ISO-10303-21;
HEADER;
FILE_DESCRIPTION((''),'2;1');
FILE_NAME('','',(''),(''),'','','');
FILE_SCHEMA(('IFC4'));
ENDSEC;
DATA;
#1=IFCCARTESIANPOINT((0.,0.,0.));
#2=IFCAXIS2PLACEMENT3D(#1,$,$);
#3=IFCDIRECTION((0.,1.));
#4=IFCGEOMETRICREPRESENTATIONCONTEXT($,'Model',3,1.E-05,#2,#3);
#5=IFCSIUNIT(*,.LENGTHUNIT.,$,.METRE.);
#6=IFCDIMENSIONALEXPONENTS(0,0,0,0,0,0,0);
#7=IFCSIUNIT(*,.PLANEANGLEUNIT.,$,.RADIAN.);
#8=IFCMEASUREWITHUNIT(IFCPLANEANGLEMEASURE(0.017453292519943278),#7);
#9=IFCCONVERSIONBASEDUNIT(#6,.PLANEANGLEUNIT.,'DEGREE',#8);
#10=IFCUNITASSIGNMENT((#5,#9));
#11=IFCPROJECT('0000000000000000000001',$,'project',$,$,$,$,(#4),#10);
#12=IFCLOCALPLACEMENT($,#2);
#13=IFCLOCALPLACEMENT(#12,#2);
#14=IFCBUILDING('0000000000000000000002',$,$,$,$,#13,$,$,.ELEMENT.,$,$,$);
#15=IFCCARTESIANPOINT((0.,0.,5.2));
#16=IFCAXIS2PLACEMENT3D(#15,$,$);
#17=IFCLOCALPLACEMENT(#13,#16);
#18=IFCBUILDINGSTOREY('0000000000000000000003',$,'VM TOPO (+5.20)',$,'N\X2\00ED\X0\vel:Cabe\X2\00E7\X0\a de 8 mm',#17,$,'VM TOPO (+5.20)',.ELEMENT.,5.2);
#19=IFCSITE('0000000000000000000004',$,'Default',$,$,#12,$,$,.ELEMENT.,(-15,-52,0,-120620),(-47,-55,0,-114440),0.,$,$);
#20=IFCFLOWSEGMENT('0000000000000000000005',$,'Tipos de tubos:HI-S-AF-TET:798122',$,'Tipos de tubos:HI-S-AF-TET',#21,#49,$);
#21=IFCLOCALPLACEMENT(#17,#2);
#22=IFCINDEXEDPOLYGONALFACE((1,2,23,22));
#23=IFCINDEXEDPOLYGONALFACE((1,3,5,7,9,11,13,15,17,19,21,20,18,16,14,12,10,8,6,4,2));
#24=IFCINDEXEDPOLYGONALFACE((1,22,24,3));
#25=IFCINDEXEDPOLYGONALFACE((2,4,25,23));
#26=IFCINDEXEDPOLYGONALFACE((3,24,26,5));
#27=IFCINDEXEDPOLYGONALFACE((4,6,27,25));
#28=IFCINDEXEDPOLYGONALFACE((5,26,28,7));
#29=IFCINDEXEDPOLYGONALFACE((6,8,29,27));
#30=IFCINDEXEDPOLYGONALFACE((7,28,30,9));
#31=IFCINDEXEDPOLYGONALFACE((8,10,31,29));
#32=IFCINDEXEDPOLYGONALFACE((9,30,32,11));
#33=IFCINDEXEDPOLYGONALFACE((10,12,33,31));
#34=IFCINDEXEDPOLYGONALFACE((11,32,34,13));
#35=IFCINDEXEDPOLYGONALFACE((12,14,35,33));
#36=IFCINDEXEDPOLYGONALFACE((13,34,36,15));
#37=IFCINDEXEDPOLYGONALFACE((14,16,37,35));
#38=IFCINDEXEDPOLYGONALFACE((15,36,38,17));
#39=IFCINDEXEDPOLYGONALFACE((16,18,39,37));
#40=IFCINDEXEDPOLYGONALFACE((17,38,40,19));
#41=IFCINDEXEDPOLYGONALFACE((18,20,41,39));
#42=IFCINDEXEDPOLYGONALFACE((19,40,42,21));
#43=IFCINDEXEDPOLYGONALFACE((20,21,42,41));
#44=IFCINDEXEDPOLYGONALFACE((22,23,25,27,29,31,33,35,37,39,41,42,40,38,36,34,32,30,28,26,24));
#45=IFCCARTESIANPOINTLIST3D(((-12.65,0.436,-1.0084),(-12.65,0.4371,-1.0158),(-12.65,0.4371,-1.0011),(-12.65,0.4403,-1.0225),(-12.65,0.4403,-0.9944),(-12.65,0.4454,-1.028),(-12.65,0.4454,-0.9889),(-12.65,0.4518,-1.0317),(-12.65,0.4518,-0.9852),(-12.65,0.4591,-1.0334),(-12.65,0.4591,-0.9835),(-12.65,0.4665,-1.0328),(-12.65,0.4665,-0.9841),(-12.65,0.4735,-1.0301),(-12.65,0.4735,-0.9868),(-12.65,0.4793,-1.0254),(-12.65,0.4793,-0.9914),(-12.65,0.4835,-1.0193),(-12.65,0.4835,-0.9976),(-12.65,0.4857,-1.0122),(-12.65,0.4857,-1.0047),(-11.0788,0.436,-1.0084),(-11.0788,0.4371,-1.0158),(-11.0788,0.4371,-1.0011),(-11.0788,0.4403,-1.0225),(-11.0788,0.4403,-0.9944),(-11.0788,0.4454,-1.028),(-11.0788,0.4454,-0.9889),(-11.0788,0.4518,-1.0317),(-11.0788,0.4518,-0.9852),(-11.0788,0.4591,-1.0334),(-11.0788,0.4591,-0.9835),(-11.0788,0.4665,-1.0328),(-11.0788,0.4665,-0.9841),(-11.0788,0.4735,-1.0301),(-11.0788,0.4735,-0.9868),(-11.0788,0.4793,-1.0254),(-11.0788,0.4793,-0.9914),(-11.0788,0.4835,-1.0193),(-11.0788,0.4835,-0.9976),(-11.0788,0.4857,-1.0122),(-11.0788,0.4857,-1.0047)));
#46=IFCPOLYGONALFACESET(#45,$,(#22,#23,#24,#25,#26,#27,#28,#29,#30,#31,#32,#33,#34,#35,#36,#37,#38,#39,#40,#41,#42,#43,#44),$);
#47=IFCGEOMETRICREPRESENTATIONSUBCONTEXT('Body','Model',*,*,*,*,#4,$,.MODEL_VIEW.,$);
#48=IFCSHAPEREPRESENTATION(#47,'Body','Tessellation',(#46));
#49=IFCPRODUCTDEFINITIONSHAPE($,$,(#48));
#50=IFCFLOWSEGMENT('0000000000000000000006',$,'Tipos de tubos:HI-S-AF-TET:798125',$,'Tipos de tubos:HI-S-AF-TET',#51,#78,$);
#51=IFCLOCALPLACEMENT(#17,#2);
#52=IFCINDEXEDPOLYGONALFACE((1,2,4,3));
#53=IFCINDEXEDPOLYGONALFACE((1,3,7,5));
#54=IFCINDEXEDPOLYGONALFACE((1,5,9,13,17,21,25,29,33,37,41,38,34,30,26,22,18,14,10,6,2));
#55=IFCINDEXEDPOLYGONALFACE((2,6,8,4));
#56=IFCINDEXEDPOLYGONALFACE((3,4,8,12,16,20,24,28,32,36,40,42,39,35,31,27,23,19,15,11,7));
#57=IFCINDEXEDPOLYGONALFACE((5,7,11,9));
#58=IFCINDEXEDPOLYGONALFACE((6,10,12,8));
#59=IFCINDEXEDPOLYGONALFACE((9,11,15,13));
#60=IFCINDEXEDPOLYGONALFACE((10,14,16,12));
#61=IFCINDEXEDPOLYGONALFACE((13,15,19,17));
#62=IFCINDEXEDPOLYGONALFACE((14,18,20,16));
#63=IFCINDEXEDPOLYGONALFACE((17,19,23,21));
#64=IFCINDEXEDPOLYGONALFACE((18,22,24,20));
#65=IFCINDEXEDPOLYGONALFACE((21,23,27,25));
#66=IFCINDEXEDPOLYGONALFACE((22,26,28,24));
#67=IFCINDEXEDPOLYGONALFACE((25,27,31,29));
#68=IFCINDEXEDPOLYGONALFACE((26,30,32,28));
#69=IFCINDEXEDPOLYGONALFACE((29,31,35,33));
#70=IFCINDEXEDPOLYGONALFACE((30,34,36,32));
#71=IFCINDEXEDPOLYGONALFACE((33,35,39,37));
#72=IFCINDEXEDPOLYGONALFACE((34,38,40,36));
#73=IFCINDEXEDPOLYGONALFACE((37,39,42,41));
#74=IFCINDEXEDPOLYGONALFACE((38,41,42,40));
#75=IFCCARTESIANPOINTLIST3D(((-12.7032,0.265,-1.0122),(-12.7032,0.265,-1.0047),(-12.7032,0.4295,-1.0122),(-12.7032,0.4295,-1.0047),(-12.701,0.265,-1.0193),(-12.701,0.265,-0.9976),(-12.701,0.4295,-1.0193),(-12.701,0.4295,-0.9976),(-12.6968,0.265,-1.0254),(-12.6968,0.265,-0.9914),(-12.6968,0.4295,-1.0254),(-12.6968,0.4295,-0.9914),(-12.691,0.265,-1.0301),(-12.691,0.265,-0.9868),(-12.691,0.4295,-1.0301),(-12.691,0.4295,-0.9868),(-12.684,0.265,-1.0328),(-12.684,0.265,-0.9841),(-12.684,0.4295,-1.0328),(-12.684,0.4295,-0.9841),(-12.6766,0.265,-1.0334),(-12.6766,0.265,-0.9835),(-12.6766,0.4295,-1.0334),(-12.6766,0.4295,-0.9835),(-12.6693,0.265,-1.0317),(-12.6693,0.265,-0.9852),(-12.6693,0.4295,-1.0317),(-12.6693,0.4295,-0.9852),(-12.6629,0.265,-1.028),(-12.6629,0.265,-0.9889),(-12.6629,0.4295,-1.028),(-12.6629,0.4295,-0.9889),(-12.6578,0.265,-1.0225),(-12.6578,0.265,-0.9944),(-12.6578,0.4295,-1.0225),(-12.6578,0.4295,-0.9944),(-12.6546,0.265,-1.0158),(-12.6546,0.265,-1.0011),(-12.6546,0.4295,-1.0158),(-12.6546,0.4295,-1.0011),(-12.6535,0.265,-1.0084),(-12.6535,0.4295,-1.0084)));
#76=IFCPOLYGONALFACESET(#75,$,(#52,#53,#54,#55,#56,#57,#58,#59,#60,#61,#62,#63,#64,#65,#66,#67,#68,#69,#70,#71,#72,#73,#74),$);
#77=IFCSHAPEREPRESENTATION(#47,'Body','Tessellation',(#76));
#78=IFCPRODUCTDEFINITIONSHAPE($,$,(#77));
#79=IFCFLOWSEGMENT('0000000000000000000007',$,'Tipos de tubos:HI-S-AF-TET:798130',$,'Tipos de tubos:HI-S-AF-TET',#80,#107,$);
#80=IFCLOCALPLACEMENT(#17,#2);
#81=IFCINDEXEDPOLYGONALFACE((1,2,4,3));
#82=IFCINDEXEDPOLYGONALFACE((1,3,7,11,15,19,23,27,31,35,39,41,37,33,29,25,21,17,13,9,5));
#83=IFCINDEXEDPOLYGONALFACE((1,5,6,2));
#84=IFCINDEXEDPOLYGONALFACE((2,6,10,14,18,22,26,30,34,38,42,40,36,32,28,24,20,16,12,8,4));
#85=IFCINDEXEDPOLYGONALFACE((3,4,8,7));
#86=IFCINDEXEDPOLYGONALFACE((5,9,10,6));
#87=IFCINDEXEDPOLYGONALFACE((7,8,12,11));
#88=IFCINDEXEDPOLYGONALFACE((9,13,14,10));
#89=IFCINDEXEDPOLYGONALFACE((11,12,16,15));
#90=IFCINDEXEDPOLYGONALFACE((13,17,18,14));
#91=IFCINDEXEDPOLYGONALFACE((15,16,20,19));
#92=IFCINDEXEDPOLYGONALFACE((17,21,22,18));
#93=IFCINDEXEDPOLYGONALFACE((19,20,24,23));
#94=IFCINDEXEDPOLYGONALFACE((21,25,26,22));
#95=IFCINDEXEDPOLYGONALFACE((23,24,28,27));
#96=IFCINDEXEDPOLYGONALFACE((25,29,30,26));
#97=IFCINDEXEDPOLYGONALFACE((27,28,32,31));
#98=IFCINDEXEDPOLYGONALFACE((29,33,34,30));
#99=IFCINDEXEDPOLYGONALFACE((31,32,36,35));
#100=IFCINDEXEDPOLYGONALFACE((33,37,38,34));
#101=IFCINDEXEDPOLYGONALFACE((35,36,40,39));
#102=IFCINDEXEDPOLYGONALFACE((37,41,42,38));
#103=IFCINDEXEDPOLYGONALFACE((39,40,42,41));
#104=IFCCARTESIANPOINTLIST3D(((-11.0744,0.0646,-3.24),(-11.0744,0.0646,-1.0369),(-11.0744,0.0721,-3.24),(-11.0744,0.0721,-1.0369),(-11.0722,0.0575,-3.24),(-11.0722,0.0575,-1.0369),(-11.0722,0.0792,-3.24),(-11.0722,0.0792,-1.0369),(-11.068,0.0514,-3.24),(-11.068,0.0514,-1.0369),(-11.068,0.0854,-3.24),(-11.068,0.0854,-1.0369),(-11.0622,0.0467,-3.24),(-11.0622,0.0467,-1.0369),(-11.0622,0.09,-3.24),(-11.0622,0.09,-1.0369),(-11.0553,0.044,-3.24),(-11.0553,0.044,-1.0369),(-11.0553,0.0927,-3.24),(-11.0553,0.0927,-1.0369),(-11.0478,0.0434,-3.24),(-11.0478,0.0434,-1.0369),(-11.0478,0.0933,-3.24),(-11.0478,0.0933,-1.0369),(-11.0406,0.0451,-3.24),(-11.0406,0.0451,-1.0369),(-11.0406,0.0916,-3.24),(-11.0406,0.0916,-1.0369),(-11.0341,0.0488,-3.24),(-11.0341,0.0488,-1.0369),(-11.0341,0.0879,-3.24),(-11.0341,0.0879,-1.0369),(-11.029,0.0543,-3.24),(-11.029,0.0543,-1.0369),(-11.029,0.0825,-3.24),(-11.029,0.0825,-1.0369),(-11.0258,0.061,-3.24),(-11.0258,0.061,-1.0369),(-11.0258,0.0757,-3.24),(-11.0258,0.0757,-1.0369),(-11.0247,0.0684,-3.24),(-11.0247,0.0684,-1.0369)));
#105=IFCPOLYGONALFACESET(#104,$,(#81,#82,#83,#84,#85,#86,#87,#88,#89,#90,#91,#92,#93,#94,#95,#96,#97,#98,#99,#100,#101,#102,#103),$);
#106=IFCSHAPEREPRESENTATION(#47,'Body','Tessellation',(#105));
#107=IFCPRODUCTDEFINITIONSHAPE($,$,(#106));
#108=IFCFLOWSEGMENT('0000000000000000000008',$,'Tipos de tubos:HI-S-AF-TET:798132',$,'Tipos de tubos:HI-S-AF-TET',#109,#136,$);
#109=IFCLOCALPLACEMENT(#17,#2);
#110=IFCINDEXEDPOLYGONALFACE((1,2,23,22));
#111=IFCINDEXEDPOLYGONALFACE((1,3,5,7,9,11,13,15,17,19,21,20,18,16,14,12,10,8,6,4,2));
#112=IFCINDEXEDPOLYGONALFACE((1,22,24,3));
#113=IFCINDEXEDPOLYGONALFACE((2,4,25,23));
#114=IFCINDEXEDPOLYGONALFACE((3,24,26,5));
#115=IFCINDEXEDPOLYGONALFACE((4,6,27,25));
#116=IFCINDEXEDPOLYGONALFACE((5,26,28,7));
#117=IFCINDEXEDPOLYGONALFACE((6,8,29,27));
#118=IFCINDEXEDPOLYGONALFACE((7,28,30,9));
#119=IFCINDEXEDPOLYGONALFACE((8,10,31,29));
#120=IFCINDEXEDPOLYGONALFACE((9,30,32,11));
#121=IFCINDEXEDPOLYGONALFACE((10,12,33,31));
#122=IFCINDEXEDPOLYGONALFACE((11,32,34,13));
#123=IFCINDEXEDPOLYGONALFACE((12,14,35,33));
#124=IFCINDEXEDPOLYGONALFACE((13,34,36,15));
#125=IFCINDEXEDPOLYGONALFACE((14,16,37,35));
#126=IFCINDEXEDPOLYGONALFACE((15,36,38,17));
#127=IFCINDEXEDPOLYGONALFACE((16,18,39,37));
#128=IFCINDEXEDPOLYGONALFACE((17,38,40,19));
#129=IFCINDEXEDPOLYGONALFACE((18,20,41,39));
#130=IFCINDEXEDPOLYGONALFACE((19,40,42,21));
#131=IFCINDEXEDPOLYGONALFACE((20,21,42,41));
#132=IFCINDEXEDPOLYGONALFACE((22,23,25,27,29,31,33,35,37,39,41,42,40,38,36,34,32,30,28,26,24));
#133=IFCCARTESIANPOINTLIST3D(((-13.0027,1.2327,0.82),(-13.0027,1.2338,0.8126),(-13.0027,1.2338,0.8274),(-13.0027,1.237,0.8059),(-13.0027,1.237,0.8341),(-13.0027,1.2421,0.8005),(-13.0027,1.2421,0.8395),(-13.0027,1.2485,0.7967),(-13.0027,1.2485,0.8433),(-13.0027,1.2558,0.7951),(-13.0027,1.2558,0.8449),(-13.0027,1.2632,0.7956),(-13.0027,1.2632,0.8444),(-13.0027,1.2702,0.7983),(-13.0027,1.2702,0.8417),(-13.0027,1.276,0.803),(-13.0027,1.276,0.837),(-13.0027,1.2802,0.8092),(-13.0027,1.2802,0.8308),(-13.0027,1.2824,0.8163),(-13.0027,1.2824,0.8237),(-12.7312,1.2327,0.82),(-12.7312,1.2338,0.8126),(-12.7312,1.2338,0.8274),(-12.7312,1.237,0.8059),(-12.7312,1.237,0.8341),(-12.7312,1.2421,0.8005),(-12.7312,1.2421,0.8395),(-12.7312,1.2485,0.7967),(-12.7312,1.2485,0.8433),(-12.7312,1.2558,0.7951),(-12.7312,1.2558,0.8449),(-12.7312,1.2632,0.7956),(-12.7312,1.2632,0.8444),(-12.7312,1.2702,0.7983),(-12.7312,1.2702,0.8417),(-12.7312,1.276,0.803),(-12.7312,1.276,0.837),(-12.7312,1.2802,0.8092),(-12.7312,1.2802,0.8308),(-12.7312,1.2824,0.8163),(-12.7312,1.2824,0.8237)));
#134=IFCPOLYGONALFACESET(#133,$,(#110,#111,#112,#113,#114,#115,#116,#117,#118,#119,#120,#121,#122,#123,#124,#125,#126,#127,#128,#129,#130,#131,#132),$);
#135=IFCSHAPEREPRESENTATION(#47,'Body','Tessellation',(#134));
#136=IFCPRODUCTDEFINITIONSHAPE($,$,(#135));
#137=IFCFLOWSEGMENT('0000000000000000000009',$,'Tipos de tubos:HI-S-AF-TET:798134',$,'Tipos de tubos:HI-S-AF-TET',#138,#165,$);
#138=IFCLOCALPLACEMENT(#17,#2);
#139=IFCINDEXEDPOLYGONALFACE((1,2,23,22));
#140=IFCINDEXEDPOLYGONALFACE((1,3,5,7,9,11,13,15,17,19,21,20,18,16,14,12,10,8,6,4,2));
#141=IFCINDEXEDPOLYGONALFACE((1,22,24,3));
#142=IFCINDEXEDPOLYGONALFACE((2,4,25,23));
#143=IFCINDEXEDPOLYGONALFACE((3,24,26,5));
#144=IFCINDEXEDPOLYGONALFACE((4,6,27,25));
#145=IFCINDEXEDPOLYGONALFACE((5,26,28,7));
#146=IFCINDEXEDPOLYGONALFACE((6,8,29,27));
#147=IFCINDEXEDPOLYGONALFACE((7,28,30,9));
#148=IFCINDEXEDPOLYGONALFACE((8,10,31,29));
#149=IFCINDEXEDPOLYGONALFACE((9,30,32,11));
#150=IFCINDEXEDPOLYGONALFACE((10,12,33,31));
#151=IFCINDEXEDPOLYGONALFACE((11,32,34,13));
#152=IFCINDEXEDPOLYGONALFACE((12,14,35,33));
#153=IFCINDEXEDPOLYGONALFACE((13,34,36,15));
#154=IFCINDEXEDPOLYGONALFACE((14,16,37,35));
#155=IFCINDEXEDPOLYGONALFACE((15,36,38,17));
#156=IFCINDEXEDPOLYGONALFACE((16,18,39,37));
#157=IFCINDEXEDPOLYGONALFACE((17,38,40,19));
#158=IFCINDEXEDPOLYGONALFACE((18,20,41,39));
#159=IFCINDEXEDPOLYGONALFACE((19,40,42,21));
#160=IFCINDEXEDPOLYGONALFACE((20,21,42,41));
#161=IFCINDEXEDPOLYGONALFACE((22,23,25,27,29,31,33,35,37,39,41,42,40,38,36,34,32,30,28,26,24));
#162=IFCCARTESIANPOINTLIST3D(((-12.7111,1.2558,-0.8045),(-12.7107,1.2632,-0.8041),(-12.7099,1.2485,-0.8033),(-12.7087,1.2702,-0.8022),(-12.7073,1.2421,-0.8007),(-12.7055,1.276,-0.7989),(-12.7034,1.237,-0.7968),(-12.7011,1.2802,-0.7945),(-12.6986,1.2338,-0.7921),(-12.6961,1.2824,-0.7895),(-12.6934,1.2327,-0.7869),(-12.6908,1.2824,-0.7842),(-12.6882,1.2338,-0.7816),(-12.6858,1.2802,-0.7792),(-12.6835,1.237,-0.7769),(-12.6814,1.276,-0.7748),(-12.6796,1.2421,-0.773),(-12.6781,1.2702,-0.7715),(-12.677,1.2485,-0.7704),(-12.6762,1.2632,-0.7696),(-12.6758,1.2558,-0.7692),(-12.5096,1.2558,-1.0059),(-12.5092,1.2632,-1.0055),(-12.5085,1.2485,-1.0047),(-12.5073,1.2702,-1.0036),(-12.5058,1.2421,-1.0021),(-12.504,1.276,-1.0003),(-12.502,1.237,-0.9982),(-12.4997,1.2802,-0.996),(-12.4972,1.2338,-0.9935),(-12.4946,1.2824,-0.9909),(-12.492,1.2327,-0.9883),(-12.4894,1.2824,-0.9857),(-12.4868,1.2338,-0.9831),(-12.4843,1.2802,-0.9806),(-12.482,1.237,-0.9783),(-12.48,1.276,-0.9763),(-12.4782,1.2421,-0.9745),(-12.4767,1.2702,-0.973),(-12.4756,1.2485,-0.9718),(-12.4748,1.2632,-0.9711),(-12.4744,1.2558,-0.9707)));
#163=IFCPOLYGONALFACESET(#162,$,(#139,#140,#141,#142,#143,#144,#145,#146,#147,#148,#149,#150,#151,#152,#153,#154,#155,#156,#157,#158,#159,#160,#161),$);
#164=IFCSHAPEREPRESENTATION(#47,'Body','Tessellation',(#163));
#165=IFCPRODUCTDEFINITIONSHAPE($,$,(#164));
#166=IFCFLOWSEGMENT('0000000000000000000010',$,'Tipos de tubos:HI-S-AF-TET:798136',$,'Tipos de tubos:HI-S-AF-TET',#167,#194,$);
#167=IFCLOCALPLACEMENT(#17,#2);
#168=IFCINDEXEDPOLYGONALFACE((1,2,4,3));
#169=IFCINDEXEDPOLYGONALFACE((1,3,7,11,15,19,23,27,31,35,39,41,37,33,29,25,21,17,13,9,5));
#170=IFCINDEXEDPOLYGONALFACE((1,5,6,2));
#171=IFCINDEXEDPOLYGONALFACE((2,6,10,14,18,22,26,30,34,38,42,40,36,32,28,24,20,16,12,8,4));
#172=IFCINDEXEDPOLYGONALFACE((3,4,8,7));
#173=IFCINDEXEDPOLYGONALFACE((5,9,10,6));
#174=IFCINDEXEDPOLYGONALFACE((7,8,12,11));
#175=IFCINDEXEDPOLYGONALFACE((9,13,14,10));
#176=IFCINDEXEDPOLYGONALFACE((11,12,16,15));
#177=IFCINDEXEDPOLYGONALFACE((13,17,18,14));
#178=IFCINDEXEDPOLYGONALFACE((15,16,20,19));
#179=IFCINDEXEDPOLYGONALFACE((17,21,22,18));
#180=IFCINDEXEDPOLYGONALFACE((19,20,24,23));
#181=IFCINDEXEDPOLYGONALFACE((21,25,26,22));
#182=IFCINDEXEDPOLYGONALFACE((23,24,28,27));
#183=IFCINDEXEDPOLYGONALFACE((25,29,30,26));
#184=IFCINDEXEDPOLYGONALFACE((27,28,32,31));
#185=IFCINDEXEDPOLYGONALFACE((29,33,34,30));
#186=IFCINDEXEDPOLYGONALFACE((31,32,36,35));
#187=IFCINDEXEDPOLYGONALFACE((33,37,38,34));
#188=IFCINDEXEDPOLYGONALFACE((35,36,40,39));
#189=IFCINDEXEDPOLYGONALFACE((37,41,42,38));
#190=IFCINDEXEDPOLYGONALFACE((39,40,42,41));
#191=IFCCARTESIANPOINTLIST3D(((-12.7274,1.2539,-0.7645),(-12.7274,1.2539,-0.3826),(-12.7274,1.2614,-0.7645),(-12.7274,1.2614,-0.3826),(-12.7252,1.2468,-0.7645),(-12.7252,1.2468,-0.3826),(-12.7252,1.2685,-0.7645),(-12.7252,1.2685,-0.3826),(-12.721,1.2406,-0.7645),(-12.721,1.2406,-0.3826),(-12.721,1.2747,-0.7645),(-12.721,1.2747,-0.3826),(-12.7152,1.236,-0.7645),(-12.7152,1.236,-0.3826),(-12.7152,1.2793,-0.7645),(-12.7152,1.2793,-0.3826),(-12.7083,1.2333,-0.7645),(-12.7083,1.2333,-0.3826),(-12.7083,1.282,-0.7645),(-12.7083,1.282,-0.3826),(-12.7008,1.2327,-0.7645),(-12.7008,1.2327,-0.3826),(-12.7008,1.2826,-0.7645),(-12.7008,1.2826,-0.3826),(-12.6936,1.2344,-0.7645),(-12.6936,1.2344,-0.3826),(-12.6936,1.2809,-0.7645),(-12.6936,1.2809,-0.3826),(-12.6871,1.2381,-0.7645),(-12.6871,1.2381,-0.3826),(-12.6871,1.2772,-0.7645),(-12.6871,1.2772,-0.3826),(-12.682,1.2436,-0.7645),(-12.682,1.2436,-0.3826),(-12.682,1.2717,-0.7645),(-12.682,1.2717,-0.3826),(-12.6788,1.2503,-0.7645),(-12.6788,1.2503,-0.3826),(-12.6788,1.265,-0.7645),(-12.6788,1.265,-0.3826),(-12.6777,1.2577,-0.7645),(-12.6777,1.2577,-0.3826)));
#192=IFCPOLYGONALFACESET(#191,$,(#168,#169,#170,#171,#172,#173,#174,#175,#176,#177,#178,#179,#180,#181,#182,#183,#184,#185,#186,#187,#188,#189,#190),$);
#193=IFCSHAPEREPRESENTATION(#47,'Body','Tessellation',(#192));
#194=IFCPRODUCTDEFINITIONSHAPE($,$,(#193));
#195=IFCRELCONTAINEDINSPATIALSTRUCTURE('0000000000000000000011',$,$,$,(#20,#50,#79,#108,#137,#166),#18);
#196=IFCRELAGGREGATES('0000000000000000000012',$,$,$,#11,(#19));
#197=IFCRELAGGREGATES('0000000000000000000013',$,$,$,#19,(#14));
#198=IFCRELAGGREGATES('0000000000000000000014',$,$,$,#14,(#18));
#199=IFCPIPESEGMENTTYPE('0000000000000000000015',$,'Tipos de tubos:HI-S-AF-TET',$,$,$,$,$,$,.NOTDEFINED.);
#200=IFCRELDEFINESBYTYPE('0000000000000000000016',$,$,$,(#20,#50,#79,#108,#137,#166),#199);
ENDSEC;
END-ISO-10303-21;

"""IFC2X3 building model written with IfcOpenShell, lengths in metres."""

from ifc_helpers import new_model, entity, si_unit, converted_unit, direction, frame, frame_2d, origin, origin_2d_with_axis, place, context, subcontext, project, spatial, circle, extrude, type_object, element, save


model = new_model("IFC2X3")

# Units and contexts
model_context = context("Model", 3, precision=1e-05, world=origin(), true_north=direction((0.0, 1.0)))
body_context = subcontext(model_context, "Body", "Model", "MODEL_VIEW")
ifc_project = project(units=[si_unit("LENGTHUNIT", "METRE"), converted_unit("PLANEANGLEUNIT", "DEGREE", entity("IfcPlaneAngleMeasure", 0.017453292519943278), si_unit("PLANEANGLEUNIT", "RADIAN"), dimensions=[0, 0, 0, 0, 0, 0, 0])], contexts=[model_context])

# Site, building, storey
site_placement = place(None, origin())
site = spatial("IfcSite", under=ifc_project, at=site_placement, Name="Default", CompositionType="ELEMENT", RefLatitude=(-15, -52, 0, -120620), RefLongitude=(-47, -55, 0, -114440), RefElevation=0.0)
building_placement = place(site_placement, origin())
building = spatial("IfcBuilding", under=site, at=building_placement, CompositionType="ELEMENT")
storey_placement = place(building_placement, frame((0.0, 0.0, 5.2)))
storey = spatial("IfcBuildingStorey", under=building, at=storey_placement, Name="VM TOPO (+5.20)", ObjectType="Nível:Cabeça de 8 mm", LongName="VM TOPO (+5.20)", CompositionType="ELEMENT", Elevation=5.2)

# Flow segments
pipe_segment_type_1 = type_object("IfcPipeSegmentType", Name="Tipos de tubos:HI-S-AF-TET", PredefinedType="NOTDEFINED")
flow_segment_1_placement = place(storey_placement, origin())
element("IfcFlowSegment", 1, at=flow_segment_1_placement, inside=storey, type_object=pipe_segment_type_1, Name="Tipos de tubos:HI-S-AF-TET:798122", ObjectType="Tipos de tubos:HI-S-AF-TET", context=body_context, shape_type="SweptSolid", body=[
    extrude(circle(Radius=0.025, at=frame_2d((0.0, 0.0), x_axis=(1.0, 0.0))), frame((-12.65, 0.461, -1.0084), z_axis=(1.0, 0.0, 0.0), x_axis=(0.0, -1.0, 0.0)), (0.0, 0.0, 1.0), 1.5712),
])
flow_segment_2_placement = place(storey_placement, origin())
element("IfcFlowSegment", 2, at=flow_segment_2_placement, inside=storey, type_object=pipe_segment_type_1, Name="Tipos de tubos:HI-S-AF-TET:798125", ObjectType="Tipos de tubos:HI-S-AF-TET", context=body_context, shape_type="SweptSolid", body=[
    extrude(circle(Radius=0.025, at=origin_2d_with_axis()), frame((-12.6785, 0.265, -1.0084), z_axis=(0.0, 1.0, 0.0), x_axis=(1.0, 0.0, 0.0)), (0.0, 0.0, 1.0), 0.1645),
])
flow_segment_3_placement = place(storey_placement, origin())
element("IfcFlowSegment", 3, at=flow_segment_3_placement, inside=storey, type_object=pipe_segment_type_1, Name="Tipos de tubos:HI-S-AF-TET:798130", ObjectType="Tipos de tubos:HI-S-AF-TET", context=body_context, shape_type="SweptSolid", body=[
    extrude(circle(Radius=0.025, at=frame_2d((0.0, 0.0), x_axis=(1.0, 0.0))), frame((-11.0497, 0.0684, -3.24)), (0.0, 0.0, 1.0), 2.2031),
])
flow_segment_4_placement = place(storey_placement, origin())
element("IfcFlowSegment", 4, at=flow_segment_4_placement, inside=storey, type_object=pipe_segment_type_1, Name="Tipos de tubos:HI-S-AF-TET:798132", ObjectType="Tipos de tubos:HI-S-AF-TET", context=body_context, shape_type="SweptSolid", body=[
    extrude(circle(Radius=0.025, at=origin_2d_with_axis()), frame((-13.0027, 1.2577, 0.82), z_axis=(1.0, 0.0, 0.0), x_axis=(0.0, -1.0, 0.0)), (0.0, 0.0, 1.0), 0.2715),
])
flow_segment_5_placement = place(storey_placement, origin())
element("IfcFlowSegment", 5, at=flow_segment_5_placement, inside=storey, type_object=pipe_segment_type_1, Name="Tipos de tubos:HI-S-AF-TET:798134", ObjectType="Tipos de tubos:HI-S-AF-TET", context=body_context, shape_type="SweptSolid", body=[
    extrude(circle(Radius=0.025, at=origin_2d_with_axis()), frame((-12.492, 1.2577, -0.9883), z_axis=(-0.707107, 0.0, 0.707107), x_axis=(0.0, -1.0, 0.0)), (0.0, 0.0, 1.0), 0.2849),
])
flow_segment_6_placement = place(storey_placement, origin())
element("IfcFlowSegment", 6, at=flow_segment_6_placement, inside=storey, type_object=pipe_segment_type_1, Name="Tipos de tubos:HI-S-AF-TET:798136", ObjectType="Tipos de tubos:HI-S-AF-TET", context=body_context, shape_type="SweptSolid", body=[
    extrude(circle(Radius=0.025, at=origin_2d_with_axis()), frame((-12.7027, 1.2577, -0.7645)), (0.0, 0.0, 1.0), 0.3819),
])

save(model, "model.ifc")
